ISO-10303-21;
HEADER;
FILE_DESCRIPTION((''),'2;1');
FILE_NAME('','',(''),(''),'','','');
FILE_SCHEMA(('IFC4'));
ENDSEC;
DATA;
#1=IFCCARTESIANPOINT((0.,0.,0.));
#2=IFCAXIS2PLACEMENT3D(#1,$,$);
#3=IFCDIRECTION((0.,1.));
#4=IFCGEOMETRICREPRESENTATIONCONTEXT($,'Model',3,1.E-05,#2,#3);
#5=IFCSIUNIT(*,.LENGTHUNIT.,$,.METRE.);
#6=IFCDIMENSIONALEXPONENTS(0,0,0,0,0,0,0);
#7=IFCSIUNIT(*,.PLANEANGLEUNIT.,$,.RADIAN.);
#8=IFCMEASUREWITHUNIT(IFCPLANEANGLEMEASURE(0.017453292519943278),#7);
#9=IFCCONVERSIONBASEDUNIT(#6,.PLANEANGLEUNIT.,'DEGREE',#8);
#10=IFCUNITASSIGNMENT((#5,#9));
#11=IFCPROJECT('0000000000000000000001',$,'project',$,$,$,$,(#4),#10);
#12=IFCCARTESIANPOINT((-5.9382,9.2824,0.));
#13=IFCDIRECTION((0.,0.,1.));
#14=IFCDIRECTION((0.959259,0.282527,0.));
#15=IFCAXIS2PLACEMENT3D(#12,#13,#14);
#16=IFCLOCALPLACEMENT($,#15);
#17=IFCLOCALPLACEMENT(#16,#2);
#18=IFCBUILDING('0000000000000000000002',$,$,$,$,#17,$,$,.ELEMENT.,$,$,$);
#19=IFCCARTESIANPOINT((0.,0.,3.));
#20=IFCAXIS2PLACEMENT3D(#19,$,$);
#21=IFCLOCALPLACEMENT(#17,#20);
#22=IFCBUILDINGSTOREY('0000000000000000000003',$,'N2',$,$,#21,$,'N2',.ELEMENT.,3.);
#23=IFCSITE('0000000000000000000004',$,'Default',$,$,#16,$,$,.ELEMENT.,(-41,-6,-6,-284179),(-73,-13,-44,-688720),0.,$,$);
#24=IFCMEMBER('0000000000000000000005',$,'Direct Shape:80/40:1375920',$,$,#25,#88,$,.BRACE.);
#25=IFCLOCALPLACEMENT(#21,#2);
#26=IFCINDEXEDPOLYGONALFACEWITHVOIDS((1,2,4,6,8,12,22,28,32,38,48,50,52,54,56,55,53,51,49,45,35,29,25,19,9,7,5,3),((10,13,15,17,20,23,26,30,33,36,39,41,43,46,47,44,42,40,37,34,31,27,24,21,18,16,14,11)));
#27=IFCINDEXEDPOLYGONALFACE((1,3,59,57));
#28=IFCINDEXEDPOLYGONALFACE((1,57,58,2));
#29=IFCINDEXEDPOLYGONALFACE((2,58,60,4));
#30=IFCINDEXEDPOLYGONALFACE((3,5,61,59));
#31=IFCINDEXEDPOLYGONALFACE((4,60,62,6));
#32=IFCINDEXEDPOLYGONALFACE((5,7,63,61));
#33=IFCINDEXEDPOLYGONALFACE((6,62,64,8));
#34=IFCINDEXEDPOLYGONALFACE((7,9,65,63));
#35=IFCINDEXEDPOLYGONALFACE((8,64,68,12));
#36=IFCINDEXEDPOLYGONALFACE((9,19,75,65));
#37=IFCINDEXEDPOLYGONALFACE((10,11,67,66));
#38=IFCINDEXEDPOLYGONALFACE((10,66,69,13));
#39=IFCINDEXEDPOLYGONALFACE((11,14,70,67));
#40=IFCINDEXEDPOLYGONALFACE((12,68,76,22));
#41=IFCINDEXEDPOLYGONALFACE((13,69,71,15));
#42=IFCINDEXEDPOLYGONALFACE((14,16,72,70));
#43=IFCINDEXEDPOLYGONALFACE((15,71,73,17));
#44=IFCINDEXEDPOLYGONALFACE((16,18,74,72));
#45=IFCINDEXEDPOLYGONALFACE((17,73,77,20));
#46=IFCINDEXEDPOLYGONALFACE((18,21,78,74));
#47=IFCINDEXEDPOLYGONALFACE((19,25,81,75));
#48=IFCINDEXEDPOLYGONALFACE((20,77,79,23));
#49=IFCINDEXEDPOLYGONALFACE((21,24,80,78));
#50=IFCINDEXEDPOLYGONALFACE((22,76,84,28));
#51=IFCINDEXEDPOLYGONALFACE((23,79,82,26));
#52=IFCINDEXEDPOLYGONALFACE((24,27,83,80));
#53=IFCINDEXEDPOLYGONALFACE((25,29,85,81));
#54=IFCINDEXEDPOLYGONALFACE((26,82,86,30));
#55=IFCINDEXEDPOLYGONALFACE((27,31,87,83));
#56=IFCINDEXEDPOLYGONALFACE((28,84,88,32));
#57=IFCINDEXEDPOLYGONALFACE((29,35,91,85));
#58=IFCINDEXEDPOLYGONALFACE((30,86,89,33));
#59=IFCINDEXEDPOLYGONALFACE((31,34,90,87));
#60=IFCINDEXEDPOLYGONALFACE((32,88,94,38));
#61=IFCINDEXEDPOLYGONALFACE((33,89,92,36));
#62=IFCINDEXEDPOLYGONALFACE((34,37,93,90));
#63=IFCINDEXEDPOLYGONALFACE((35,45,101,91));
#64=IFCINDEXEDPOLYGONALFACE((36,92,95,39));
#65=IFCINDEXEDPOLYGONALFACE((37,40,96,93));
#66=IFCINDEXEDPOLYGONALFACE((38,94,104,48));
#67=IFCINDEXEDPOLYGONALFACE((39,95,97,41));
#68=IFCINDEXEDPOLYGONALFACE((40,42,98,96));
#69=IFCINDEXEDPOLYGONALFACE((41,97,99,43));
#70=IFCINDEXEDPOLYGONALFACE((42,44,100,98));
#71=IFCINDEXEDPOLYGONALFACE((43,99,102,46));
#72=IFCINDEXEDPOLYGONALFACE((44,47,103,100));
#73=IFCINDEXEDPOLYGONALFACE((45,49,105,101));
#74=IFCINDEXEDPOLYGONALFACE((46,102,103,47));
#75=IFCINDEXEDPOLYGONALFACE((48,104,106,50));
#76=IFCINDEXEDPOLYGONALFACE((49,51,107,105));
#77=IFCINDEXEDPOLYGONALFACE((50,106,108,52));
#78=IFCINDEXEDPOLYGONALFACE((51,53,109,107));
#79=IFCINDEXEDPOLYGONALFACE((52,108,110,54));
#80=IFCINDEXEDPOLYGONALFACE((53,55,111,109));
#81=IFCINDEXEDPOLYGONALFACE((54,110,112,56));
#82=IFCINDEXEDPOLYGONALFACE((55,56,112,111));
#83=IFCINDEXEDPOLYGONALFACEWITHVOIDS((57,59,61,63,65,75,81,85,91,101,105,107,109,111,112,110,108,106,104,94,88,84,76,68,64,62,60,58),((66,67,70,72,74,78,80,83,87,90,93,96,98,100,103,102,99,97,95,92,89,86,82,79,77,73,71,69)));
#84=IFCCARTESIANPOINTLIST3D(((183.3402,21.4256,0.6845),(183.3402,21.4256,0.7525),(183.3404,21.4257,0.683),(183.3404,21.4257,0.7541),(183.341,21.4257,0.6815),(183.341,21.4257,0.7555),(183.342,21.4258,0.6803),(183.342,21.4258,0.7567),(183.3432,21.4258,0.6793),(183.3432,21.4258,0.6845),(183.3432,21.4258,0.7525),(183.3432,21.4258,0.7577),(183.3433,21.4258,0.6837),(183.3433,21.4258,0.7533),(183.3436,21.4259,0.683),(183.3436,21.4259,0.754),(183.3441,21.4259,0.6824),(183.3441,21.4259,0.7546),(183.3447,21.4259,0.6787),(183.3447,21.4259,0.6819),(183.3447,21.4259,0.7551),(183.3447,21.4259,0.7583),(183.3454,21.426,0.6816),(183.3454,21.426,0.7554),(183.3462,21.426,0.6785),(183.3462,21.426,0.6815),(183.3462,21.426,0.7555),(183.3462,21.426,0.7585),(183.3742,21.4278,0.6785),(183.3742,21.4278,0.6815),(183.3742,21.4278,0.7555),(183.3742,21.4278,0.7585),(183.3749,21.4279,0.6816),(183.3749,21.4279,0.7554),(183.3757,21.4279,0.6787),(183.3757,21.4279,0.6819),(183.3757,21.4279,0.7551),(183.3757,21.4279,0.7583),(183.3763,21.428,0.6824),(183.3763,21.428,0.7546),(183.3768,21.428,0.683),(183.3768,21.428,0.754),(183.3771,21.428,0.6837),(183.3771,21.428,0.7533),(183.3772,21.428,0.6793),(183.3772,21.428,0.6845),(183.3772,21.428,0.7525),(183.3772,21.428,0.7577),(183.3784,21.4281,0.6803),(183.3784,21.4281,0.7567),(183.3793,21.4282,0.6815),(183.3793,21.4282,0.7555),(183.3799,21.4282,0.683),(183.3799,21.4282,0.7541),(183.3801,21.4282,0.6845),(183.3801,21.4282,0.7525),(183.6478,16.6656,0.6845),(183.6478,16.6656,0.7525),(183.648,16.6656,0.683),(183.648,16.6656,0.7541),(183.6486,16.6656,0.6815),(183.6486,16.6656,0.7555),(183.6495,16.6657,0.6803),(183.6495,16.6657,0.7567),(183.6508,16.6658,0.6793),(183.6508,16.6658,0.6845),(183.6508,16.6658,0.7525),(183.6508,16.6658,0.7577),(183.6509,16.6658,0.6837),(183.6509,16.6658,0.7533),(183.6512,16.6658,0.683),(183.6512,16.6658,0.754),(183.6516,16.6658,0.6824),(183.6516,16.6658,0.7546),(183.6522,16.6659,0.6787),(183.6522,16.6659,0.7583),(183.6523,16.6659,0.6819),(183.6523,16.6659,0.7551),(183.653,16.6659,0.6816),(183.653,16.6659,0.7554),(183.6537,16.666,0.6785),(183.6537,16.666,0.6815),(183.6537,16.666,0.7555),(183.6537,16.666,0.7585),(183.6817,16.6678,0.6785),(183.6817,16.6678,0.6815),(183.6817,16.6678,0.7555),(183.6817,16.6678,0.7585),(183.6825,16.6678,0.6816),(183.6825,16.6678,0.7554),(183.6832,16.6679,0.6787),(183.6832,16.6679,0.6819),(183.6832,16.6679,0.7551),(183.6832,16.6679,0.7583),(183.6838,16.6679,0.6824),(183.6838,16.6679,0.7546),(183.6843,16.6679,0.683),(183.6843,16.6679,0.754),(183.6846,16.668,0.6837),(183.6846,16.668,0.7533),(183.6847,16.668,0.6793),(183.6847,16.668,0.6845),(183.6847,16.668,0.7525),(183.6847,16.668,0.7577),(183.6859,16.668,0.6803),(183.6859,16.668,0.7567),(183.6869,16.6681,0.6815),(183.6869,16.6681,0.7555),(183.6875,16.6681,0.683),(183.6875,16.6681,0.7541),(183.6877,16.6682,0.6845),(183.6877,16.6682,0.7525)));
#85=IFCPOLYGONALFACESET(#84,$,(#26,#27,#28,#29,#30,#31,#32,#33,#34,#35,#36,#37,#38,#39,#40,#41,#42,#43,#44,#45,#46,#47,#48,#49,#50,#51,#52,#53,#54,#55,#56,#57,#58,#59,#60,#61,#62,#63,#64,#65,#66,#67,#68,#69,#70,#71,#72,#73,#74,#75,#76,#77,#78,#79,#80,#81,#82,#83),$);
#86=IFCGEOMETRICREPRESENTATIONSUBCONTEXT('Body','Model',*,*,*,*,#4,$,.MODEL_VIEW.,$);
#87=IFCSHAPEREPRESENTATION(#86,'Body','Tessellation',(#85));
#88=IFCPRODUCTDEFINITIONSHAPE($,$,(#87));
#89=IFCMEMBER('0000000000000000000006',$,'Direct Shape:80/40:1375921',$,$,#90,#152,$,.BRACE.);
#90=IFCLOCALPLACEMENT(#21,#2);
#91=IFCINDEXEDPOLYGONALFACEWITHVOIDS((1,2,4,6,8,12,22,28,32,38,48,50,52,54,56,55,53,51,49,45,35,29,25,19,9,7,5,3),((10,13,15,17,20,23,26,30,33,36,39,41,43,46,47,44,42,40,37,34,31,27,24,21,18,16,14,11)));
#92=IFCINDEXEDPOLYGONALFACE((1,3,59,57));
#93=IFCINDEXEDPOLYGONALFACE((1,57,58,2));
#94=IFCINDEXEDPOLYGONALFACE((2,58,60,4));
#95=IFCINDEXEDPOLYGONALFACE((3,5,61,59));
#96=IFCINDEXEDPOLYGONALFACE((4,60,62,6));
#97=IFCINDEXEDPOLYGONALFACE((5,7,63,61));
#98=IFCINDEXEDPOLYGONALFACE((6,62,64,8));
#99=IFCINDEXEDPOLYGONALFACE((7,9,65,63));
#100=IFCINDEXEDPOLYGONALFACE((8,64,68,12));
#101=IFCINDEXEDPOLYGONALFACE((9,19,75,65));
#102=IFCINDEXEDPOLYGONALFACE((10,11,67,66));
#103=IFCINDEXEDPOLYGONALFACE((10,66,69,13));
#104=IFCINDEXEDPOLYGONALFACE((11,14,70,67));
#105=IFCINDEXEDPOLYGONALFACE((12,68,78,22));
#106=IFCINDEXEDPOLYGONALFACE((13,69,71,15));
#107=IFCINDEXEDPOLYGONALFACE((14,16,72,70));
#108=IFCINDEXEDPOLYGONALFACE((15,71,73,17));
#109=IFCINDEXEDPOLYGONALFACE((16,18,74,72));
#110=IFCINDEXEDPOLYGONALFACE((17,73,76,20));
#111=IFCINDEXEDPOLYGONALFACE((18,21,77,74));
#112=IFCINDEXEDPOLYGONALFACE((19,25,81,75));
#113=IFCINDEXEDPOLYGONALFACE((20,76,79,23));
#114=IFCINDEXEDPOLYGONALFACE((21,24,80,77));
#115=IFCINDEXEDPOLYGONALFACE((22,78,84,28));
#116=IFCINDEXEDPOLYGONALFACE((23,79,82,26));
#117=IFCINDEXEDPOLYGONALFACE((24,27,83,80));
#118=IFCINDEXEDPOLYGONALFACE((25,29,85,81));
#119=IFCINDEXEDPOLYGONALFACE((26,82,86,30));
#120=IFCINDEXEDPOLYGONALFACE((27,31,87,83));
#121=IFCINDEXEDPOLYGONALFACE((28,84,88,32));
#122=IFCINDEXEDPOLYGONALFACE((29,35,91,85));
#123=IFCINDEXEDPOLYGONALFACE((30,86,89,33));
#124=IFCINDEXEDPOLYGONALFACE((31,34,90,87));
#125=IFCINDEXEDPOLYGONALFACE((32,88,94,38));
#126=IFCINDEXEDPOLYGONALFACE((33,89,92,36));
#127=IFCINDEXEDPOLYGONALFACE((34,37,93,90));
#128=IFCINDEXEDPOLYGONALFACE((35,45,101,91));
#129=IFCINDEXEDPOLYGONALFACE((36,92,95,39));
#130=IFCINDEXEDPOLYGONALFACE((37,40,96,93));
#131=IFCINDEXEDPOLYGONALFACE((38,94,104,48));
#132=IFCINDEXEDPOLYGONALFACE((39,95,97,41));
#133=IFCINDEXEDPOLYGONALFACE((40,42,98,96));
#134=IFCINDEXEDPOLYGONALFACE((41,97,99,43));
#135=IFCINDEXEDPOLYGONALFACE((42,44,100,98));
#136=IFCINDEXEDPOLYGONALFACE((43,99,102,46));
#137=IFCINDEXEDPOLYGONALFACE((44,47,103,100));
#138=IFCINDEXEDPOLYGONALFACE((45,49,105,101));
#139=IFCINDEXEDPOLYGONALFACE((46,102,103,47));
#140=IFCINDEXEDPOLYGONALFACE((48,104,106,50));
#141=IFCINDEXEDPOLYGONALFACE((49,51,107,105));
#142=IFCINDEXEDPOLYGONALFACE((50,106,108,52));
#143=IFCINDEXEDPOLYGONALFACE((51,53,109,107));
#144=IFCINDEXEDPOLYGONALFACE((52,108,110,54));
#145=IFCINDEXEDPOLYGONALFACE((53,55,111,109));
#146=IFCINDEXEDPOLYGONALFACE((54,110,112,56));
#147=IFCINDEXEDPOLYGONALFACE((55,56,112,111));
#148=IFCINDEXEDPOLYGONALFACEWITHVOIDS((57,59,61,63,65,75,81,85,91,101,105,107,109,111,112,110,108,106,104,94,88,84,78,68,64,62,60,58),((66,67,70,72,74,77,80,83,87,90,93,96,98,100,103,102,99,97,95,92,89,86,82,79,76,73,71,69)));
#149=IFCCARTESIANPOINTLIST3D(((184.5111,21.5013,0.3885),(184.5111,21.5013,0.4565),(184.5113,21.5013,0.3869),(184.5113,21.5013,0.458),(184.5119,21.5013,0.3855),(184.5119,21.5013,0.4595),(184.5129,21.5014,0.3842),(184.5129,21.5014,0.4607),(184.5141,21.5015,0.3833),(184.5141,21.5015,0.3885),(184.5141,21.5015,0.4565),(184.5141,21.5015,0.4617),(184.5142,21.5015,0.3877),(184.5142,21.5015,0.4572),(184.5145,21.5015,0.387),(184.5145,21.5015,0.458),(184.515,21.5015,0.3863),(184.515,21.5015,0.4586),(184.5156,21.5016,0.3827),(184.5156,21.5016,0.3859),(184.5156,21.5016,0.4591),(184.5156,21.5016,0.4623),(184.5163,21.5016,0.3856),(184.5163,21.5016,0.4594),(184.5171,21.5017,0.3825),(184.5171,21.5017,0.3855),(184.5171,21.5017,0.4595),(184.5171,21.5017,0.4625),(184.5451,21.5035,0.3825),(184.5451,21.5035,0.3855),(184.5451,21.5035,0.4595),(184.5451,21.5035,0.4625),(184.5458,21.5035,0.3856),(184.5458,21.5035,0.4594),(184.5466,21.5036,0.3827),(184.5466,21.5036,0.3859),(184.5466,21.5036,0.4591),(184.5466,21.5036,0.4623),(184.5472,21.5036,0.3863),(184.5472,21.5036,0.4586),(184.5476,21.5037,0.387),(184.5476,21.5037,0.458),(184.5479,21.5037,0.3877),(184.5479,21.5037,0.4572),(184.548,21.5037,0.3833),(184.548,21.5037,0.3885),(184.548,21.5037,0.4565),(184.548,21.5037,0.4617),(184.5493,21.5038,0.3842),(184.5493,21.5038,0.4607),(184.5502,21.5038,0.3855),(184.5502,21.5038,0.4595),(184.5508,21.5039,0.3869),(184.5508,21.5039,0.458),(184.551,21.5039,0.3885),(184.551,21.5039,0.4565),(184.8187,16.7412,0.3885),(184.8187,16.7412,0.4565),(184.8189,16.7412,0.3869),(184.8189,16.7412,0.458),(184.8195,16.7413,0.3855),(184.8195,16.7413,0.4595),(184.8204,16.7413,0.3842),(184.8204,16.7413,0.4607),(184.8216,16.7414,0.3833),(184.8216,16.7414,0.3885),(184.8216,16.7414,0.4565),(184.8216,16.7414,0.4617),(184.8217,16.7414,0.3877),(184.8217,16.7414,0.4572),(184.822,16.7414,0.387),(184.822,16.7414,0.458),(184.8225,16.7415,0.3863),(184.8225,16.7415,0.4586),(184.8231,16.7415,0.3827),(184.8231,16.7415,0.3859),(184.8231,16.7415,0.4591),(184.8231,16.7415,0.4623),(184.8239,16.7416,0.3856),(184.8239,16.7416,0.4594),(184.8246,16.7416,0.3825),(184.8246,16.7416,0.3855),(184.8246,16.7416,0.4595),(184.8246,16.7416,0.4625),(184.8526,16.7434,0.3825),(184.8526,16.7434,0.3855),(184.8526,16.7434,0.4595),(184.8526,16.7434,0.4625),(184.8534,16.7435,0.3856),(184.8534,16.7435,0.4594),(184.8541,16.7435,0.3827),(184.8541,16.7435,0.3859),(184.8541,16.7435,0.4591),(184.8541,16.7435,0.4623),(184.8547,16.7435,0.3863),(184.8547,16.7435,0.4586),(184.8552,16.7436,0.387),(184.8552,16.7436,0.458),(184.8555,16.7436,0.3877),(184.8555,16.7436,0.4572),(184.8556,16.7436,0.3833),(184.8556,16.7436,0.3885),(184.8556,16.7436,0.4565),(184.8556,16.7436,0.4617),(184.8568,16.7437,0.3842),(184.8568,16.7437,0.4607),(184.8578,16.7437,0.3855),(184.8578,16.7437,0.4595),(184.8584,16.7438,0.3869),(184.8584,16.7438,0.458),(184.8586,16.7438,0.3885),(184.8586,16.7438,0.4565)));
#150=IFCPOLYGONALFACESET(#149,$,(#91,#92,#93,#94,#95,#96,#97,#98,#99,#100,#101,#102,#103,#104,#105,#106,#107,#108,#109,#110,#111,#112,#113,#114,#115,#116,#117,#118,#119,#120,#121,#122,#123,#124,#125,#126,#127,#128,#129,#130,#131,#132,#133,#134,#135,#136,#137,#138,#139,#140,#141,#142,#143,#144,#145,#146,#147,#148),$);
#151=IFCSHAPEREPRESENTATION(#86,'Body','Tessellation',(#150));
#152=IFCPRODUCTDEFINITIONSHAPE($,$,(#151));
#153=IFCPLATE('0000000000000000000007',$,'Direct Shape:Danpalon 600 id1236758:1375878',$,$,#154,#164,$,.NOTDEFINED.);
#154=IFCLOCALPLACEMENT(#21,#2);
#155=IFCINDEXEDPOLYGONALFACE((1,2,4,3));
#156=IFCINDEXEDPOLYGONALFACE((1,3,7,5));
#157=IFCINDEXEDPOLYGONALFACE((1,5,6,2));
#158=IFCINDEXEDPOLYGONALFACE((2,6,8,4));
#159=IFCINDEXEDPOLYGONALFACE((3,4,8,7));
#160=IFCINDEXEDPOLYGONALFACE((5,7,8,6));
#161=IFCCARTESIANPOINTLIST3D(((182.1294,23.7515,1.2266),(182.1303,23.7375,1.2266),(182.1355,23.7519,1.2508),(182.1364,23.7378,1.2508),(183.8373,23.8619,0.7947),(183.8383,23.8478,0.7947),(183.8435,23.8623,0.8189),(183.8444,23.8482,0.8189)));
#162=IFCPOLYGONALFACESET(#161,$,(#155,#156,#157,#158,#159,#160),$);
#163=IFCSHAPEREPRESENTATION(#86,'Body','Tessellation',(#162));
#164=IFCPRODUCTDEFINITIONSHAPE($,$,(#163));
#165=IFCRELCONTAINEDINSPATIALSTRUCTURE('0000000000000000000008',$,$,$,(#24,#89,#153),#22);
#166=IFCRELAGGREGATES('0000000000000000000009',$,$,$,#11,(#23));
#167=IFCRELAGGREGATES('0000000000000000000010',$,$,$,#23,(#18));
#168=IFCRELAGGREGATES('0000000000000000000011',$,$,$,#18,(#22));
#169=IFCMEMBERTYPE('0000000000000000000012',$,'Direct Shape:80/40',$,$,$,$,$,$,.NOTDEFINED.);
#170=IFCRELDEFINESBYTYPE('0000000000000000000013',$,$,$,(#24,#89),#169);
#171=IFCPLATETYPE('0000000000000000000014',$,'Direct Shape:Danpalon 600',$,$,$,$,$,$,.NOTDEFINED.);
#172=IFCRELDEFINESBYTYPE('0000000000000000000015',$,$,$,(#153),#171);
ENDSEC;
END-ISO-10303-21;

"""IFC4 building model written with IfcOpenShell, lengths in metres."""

from ifc_helpers import new_model, entity, si_unit, converted_unit, direction, frame, frame_2d, origin, place, context, subcontext, project, spatial, polyline, circle_curve, parameter, trimmed, segment, composite_curve, rectangle, outline, extrude, type_object, element, save


model = new_model("IFC4")

# Units and contexts
model_context = context("Model", 3, precision=1e-05, world=origin(), true_north=direction((0.0, 1.0)))
body_context = subcontext(model_context, "Body", "Model", "MODEL_VIEW")
ifc_project = project(units=[si_unit("LENGTHUNIT", "METRE"), converted_unit("PLANEANGLEUNIT", "DEGREE", entity("IfcPlaneAngleMeasure", 0.017453292519943278), si_unit("PLANEANGLEUNIT", "RADIAN"), dimensions=[0, 0, 0, 0, 0, 0, 0])], contexts=[model_context])

# Site, building, storey
site_placement = place(None, frame((-5.9382, 9.2824, 0.0), z_axis=(0.0, 0.0, 1.0), x_axis=(0.959259, 0.282527, 0.0)))
site = spatial("IfcSite", under=ifc_project, at=site_placement, Name="Default", CompositionType="ELEMENT", RefLatitude=(-41, -6, -6, -284179), RefLongitude=(-73, -13, -44, -688720), RefElevation=0.0)
building_placement = place(site_placement, origin())
building = spatial("IfcBuilding", under=site, at=building_placement, CompositionType="ELEMENT")
storey_placement = place(building_placement, frame((0.0, 0.0, 3.0)))
storey = spatial("IfcBuildingStorey", under=building, at=storey_placement, Name="N2", LongName="N2", CompositionType="ELEMENT", Elevation=3.0)

# Members
member_type_1 = type_object("IfcMemberType", Name="Direct Shape:80/40", PredefinedType="NOTDEFINED")
member_1_placement = place(storey_placement, origin())
element("IfcMember", 1, at=member_1_placement, inside=storey, type_object=member_type_1, Name="Direct Shape:80/40:1375920", PredefinedType="BRACE", context=body_context, shape_type="SweptSolid", body=[
    extrude(outline(composite_curve([segment(polyline([(-0.034, -0.02), (0.034, -0.02)]), True, "CONTINUOUS"), segment(trimmed(circle_curve(frame_2d((0.034, -0.014), x_axis=(0.0, 1.0)), 0.006), [parameter(180.0)], [parameter(270.0)], True, "PARAMETER"), True, "CONTINUOUS"), segment(polyline([(0.04, -0.014), (0.04, 0.014)]), True, "CONTINUOUS"), segment(trimmed(circle_curve(frame_2d((0.034, 0.014), x_axis=(0.0, 1.0)), 0.006), [parameter(270.0)], [parameter(0.0)], True, "PARAMETER"), True, "CONTINUOUS"), segment(polyline([(0.034, 0.02), (-0.034, 0.02)]), True, "CONTINUOUS"), segment(trimmed(circle_curve(frame_2d((-0.034, 0.014), x_axis=(0.0, 1.0)), 0.006), [parameter(0.0)], [parameter(90.0)], True, "PARAMETER"), True, "CONTINUOUS"), segment(polyline([(-0.04, 0.014), (-0.04, -0.014)]), True, "CONTINUOUS"), segment(trimmed(circle_curve(frame_2d((-0.034, -0.014), x_axis=(0.0, 1.0)), 0.006), [parameter(90.0)], [parameter(180.0)], True, "PARAMETER"), True, "CONTINUOUS")], self_intersect=False), holes=[composite_curve([segment(trimmed(circle_curve(frame_2d((-0.034, 0.014), x_axis=(0.0, 1.0)), 0.003), [parameter(360.0)], [parameter(90.0)], True, "PARAMETER"), False, "CONTINUOUS"), segment(polyline([(-0.034, 0.017), (0.034, 0.017)]), True, "CONTINUOUS"), segment(trimmed(circle_curve(frame_2d((0.034, 0.014), x_axis=(0.0, 1.0)), 0.003), [parameter(270.0)], [parameter(0.0)], True, "PARAMETER"), False, "CONTINUOUS"), segment(polyline([(0.037, 0.014), (0.037, -0.014)]), True, "CONTINUOUS"), segment(trimmed(circle_curve(frame_2d((0.034, -0.014), x_axis=(0.0, 1.0)), 0.003), [parameter(180.0)], [parameter(270.0)], True, "PARAMETER"), False, "CONTINUOUS"), segment(polyline([(0.034, -0.017), (-0.034, -0.017)]), True, "CONTINUOUS"), segment(trimmed(circle_curve(frame_2d((-0.034, -0.014), x_axis=(0.0, 1.0)), 0.003), [parameter(90.0)], [parameter(180.0)], True, "PARAMETER"), False, "CONTINUOUS"), segment(polyline([(-0.037, -0.014), (-0.037, 0.014)]), True, "CONTINUOUS")], self_intersect=False)]), frame((183.6677, 16.6669, 0.7185), z_axis=(-0.064471, 0.99792, 0.0), x_axis=(0.0, 0.0, -1.0)), (0.0, 0.0, 1.0), 4.77),
])
member_2_placement = place(storey_placement, origin())
element("IfcMember", 2, at=member_2_placement, inside=storey, type_object=member_type_1, Name="Direct Shape:80/40:1375921", PredefinedType="BRACE", context=body_context, shape_type="SweptSolid", body=[
    extrude(outline(composite_curve([segment(polyline([(-0.034, -0.02), (0.034, -0.02)]), True, "CONTINUOUS"), segment(trimmed(circle_curve(frame_2d((0.034, -0.014), x_axis=(0.0, 1.0)), 0.006), [parameter(180.0)], [parameter(270.0)], True, "PARAMETER"), True, "CONTINUOUS"), segment(polyline([(0.04, -0.014), (0.04, 0.014)]), True, "CONTINUOUS"), segment(trimmed(circle_curve(frame_2d((0.034, 0.014), x_axis=(0.0, 1.0)), 0.006), [parameter(270.0)], [parameter(0.0)], True, "PARAMETER"), True, "CONTINUOUS"), segment(polyline([(0.034, 0.02), (-0.034, 0.02)]), True, "CONTINUOUS"), segment(trimmed(circle_curve(frame_2d((-0.034, 0.014), x_axis=(0.0, 1.0)), 0.006), [parameter(0.0)], [parameter(90.0)], True, "PARAMETER"), True, "CONTINUOUS"), segment(polyline([(-0.04, 0.014), (-0.04, -0.014)]), True, "CONTINUOUS"), segment(trimmed(circle_curve(frame_2d((-0.034, -0.014), x_axis=(0.0, 1.0)), 0.006), [parameter(90.0)], [parameter(180.0)], True, "PARAMETER"), True, "CONTINUOUS")], self_intersect=False), holes=[composite_curve([segment(trimmed(circle_curve(frame_2d((-0.034, 0.014), x_axis=(0.0, 1.0)), 0.003), [parameter(360.0)], [parameter(90.0)], True, "PARAMETER"), False, "CONTINUOUS"), segment(polyline([(-0.034, 0.017), (0.034, 0.017)]), True, "CONTINUOUS"), segment(trimmed(circle_curve(frame_2d((0.034, 0.014), x_axis=(0.0, 1.0)), 0.003), [parameter(270.0)], [parameter(0.0)], True, "PARAMETER"), False, "CONTINUOUS"), segment(polyline([(0.037, 0.014), (0.037, -0.014)]), True, "CONTINUOUS"), segment(trimmed(circle_curve(frame_2d((0.034, -0.014), x_axis=(0.0, 1.0)), 0.003), [parameter(180.0)], [parameter(270.0)], True, "PARAMETER"), False, "CONTINUOUS"), segment(polyline([(0.034, -0.017), (-0.034, -0.017)]), True, "CONTINUOUS"), segment(trimmed(circle_curve(frame_2d((-0.034, -0.014), x_axis=(0.0, 1.0)), 0.003), [parameter(90.0)], [parameter(180.0)], True, "PARAMETER"), False, "CONTINUOUS"), segment(polyline([(-0.037, -0.014), (-0.037, 0.014)]), True, "CONTINUOUS")], self_intersect=False)]), frame((184.8386, 16.7425, 0.4225), z_axis=(-0.064471, 0.99792, 0.0), x_axis=(0.0, 0.0, -1.0)), (0.0, 0.0, 1.0), 4.77),
])

# Plate
plate_type = type_object("IfcPlateType", Name="Direct Shape:Danpalon 600", PredefinedType="NOTDEFINED")
plate_1_placement = place(storey_placement, origin())
element("IfcPlate", 3, at=plate_1_placement, inside=storey, type_object=plate_type, Name="Direct Shape:Danpalon 600 id1236758:1375878", PredefinedType="NOTDEFINED", context=body_context, shape_type="SweptSolid", body=[
    extrude(rectangle(XDim=0.025, YDim=0.0141, at=frame_2d((0.0, 0.0), x_axis=(0.0, 1.0))), frame((182.1329, 23.7447, 1.2387), z_axis=(0.967595, 0.062512, -0.244649), x_axis=(0.064471, -0.99792, 0.0)), (0.0, 0.0, 1.0), 1.7652),
])

save(model, "model.ifc")
